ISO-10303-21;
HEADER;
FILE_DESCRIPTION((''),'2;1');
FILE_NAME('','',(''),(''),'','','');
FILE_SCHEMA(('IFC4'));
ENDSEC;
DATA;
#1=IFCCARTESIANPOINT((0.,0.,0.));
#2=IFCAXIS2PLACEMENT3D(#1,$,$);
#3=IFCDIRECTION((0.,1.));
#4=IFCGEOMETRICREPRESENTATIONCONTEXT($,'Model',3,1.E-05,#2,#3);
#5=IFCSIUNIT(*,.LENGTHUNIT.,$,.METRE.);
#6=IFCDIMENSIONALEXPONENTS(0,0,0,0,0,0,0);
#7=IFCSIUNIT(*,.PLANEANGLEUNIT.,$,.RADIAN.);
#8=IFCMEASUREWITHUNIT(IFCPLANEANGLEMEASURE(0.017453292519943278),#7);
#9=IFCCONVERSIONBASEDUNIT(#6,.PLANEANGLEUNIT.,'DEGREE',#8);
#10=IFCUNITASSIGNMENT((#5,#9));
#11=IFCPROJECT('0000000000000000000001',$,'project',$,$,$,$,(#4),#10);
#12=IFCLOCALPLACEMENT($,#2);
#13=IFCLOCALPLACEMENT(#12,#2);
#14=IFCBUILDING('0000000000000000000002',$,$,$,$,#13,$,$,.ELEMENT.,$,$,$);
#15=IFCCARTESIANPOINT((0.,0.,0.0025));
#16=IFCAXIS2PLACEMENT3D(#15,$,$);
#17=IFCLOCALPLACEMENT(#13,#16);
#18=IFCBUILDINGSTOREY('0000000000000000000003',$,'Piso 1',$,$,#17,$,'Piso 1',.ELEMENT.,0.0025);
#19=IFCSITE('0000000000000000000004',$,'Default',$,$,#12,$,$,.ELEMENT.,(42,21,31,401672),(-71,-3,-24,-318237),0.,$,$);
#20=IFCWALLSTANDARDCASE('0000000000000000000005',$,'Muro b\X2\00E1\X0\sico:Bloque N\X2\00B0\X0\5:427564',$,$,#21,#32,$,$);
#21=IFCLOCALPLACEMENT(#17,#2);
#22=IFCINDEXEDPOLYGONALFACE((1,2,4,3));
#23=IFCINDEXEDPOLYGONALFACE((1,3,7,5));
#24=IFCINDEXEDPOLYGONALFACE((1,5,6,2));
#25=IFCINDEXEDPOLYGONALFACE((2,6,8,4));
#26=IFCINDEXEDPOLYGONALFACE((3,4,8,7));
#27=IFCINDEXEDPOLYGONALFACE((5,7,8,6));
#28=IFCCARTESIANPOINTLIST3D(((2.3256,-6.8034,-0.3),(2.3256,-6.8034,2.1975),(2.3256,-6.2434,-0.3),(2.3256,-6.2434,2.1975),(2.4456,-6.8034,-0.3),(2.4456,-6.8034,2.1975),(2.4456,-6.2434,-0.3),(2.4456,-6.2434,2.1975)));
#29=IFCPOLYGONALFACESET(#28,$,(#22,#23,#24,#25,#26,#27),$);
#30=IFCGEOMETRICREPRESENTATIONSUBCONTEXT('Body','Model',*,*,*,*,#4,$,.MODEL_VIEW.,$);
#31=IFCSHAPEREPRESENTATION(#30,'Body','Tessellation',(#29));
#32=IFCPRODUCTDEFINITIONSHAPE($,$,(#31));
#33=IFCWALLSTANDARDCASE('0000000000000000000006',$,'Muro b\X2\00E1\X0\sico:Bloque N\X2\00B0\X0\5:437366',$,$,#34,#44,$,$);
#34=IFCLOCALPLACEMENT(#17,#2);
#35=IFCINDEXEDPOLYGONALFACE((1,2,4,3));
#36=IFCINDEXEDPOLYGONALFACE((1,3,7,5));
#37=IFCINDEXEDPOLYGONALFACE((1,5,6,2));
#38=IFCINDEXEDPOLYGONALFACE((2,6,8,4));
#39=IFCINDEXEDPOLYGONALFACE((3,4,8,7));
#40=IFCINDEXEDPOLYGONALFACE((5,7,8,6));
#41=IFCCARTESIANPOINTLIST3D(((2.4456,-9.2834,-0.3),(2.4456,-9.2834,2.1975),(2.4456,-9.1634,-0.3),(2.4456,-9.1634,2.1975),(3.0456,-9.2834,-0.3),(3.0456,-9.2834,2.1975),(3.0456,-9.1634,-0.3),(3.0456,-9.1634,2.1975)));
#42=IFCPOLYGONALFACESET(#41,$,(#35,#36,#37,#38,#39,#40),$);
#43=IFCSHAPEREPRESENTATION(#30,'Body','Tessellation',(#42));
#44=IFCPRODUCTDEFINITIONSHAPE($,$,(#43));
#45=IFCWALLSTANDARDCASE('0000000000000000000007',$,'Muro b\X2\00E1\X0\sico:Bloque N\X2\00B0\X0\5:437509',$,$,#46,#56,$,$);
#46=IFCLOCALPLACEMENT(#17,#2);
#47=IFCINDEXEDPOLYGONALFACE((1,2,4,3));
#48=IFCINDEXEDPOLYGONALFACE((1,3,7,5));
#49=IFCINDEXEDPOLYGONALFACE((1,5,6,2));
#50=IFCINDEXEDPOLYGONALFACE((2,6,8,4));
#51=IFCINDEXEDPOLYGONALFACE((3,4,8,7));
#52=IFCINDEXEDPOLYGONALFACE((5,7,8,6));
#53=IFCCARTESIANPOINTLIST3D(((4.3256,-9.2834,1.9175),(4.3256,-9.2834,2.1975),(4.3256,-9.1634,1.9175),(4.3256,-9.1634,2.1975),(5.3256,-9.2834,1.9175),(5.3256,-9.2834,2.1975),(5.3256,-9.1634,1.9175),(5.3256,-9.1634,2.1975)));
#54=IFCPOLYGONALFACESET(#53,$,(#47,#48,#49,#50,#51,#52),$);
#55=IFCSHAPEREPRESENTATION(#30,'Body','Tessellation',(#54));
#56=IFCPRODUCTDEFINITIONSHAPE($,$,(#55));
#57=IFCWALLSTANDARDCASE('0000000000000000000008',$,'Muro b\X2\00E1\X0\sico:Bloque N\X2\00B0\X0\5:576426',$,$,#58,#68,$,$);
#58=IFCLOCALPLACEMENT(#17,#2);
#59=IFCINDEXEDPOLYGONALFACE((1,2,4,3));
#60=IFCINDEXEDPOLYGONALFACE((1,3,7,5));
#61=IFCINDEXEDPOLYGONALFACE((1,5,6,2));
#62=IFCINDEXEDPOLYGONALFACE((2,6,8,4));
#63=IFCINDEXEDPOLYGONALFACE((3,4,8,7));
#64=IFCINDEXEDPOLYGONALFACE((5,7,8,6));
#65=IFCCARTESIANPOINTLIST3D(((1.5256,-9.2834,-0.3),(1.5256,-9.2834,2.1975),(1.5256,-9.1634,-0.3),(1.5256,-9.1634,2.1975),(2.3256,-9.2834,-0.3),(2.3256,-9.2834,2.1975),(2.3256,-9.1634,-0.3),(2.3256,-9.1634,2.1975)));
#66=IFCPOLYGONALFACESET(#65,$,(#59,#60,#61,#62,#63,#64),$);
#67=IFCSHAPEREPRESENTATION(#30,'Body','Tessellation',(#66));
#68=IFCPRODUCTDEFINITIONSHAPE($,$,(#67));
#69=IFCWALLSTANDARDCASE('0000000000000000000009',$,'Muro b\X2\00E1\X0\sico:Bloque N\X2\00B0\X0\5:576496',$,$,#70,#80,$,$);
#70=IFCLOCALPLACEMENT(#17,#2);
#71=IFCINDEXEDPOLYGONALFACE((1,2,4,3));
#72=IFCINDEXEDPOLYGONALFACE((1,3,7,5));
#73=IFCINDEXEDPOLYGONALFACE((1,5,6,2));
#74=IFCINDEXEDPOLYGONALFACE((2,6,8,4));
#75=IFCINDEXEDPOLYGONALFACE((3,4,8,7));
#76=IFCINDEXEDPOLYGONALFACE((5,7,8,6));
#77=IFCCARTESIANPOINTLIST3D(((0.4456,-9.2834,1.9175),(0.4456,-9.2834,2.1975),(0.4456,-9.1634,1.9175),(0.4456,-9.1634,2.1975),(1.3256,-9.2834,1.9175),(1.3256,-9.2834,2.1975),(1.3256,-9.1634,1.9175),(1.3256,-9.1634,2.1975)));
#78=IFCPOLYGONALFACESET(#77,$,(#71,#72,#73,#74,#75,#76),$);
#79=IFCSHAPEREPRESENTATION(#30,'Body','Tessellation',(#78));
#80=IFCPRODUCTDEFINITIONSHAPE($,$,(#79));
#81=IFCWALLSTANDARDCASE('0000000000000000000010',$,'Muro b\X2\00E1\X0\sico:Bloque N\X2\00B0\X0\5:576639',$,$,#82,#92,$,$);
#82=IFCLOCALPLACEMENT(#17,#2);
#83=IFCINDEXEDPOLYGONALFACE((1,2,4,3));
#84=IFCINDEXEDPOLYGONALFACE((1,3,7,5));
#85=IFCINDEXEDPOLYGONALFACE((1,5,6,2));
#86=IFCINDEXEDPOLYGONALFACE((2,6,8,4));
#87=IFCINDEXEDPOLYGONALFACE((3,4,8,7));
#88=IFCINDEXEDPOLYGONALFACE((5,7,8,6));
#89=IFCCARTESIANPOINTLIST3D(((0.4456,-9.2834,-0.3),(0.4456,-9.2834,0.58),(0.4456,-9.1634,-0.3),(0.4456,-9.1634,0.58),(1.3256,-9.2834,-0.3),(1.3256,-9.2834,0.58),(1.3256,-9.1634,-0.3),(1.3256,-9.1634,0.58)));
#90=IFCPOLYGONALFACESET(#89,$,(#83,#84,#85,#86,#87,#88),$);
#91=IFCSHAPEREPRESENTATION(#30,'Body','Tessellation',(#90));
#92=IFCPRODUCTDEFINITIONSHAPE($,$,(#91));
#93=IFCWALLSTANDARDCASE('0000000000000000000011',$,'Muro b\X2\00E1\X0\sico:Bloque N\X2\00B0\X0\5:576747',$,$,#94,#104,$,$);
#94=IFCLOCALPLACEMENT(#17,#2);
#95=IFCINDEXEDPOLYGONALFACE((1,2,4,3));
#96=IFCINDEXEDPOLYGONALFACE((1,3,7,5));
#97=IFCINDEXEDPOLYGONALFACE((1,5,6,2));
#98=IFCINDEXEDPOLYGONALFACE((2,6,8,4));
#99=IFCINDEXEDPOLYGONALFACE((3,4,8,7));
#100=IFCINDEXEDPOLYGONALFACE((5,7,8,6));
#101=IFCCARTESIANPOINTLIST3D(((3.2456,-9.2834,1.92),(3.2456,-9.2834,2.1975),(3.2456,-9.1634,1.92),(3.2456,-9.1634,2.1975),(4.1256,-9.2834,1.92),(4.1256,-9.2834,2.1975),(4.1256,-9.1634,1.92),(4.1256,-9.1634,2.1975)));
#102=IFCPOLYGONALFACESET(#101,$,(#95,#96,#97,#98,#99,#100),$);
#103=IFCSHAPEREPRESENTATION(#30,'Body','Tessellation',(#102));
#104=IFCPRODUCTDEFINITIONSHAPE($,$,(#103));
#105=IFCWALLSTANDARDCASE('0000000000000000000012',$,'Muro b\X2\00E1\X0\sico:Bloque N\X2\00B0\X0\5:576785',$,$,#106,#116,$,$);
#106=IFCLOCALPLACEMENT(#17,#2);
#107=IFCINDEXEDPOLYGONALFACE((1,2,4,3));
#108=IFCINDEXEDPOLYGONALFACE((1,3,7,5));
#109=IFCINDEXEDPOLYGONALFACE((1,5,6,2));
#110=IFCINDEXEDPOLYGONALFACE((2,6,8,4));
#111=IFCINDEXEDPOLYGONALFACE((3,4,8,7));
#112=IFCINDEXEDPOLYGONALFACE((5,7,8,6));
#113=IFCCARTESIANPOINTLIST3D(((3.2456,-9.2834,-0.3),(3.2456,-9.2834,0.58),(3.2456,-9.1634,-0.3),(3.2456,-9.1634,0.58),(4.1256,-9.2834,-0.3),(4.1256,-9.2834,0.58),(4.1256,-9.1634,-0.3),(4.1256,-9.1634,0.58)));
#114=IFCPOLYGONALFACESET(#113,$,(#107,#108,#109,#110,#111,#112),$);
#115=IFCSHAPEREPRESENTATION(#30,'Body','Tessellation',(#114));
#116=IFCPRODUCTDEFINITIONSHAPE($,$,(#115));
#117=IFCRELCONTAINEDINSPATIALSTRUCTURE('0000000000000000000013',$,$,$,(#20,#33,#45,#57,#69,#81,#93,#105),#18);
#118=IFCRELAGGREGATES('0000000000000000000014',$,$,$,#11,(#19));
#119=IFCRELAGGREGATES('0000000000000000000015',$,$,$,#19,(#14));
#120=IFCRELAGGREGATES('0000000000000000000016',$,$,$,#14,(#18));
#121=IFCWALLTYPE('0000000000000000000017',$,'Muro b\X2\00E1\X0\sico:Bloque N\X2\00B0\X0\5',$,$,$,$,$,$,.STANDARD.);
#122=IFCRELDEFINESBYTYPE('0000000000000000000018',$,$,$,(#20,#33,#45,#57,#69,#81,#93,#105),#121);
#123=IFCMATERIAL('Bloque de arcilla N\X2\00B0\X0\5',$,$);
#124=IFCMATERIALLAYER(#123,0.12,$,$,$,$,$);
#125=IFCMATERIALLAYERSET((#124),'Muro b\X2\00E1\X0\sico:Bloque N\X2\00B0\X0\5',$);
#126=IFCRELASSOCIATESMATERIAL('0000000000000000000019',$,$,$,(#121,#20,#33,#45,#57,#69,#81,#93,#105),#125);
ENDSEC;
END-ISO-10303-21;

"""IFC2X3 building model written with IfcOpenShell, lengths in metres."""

from ifc_helpers import new_model, entity, si_unit, converted_unit, direction, frame, frame_2d, origin, place, context, subcontext, project, spatial, rectangle, extrude, clip, halfspace, material, layer, layer_set, layer_usage, type_object, element, save


model = new_model("IFC2X3")

# Units and contexts
model_context = context("Model", 3, precision=1e-05, world=origin(), true_north=direction((0.0, 1.0)))
body_context = subcontext(model_context, "Body", "Model", "MODEL_VIEW")
ifc_project = project(units=[si_unit("LENGTHUNIT", "METRE"), converted_unit("PLANEANGLEUNIT", "DEGREE", entity("IfcPlaneAngleMeasure", 0.017453292519943278), si_unit("PLANEANGLEUNIT", "RADIAN"), dimensions=[0, 0, 0, 0, 0, 0, 0])], contexts=[model_context])

# Site, building, storey
site_placement = place(None, origin())
site = spatial("IfcSite", under=ifc_project, at=site_placement, Name="Default", CompositionType="ELEMENT", RefLatitude=(42, 21, 31, 401672), RefLongitude=(-71, -3, -24, -318237), RefElevation=0.0)
building_placement = place(site_placement, origin())
building = spatial("IfcBuilding", under=site, at=building_placement, CompositionType="ELEMENT")
storey_placement = place(building_placement, frame((0.0, 0.0, 0.0025)))
storey = spatial("IfcBuildingStorey", under=building, at=storey_placement, Name="Piso 1", LongName="Piso 1", CompositionType="ELEMENT", Elevation=0.0025)

# Walls
ifc_material_1 = material(Name="Bloque de arcilla N°5")
ifc_layer = layer(ifc_material_1, 0.12)
ifc_layer_set = layer_set([ifc_layer], Name="Muro básico:Bloque N°5")
wall_type = type_object("IfcWallType", Name="Muro básico:Bloque N°5", PredefinedType="STANDARD", material=ifc_layer_set)
ifc_layer_usage_1 = layer_usage(ifc_layer_set, "AXIS2", "NEGATIVE", 0.06)
wall_1_placement = place(storey_placement, frame((2.3856, -6.8034, -0.3), z_axis=(0.0, 0.0, 1.0), x_axis=(0.0, 1.0, 0.0)))
element("IfcWallStandardCase", 1, at=wall_1_placement, inside=storey, type_object=wall_type, material=ifc_layer_usage_1, Name="Muro básico:Bloque N°5:427564", context=body_context, shape_type="SweptSolid", body=[
    extrude(rectangle(XDim=0.56, YDim=0.12, at=frame_2d((0.28, 0.0), x_axis=(-1.0, 0.0))), origin(), (0.0, 0.0, 1.0), 2.4975),
])
ifc_layer_usage_2 = layer_usage(ifc_layer_set, "AXIS2", "NEGATIVE", 0.06)
wall_2_placement = place(storey_placement, frame((2.4456, -9.2234, -0.3)))
element("IfcWallStandardCase", 2, at=wall_2_placement, inside=storey, type_object=wall_type, material=ifc_layer_usage_2, Name="Muro básico:Bloque N°5:437366", context=body_context, shape_type="SweptSolid", body=[
    extrude(rectangle(XDim=0.6, YDim=0.12, at=frame_2d((0.3, 0.0), x_axis=(-1.0, 0.0))), origin(), (0.0, 0.0, 1.0), 2.4975),
])
ifc_layer_usage_3 = layer_usage(ifc_layer_set, "AXIS2", "NEGATIVE", 0.06)
wall_3_placement = place(storey_placement, frame((4.3256, -9.2234, 1.9175)))
element("IfcWallStandardCase", 3, at=wall_3_placement, inside=storey, type_object=wall_type, material=ifc_layer_usage_3, Name="Muro básico:Bloque N°5:437509", context=body_context, shape_type="Clipping", body=[
    clip(extrude(rectangle(XDim=1.0, YDim=0.12, at=frame_2d((0.5, 0.0), x_axis=(-1.0, 0.0))), origin(), (0.0, 0.0, 1.0), 0.28), halfspace(frame((1.0, -0.06, 0.0), z_axis=(0.0, 0.0, -1.0), x_axis=(0.0, 1.0, 0.0)), False)),
])
ifc_layer_usage_4 = layer_usage(ifc_layer_set, "AXIS2", "NEGATIVE", 0.06)
wall_4_placement = place(storey_placement, frame((2.3256, -9.2234, -0.3), z_axis=(0.0, 0.0, 1.0), x_axis=(-1.0, 0.0, 0.0)))
element("IfcWallStandardCase", 4, at=wall_4_placement, inside=storey, type_object=wall_type, material=ifc_layer_usage_4, Name="Muro básico:Bloque N°5:576426", context=body_context, shape_type="SweptSolid", body=[
    extrude(rectangle(XDim=0.8, YDim=0.12, at=frame_2d((0.4, 0.0), x_axis=(-1.0, 0.0))), origin(), (0.0, 0.0, 1.0), 2.4975),
])
ifc_layer_usage_5 = layer_usage(ifc_layer_set, "AXIS2", "NEGATIVE", 0.06)
wall_5_placement = place(storey_placement, frame((1.3256, -9.2234, 1.9175), z_axis=(0.0, 0.0, 1.0), x_axis=(-1.0, 0.0, 0.0)))
element("IfcWallStandardCase", 5, at=wall_5_placement, inside=storey, type_object=wall_type, material=ifc_layer_usage_5, Name="Muro básico:Bloque N°5:576496", context=body_context, shape_type="SweptSolid", body=[
    extrude(rectangle(XDim=0.88, YDim=0.12, at=frame_2d((0.44, 0.0), x_axis=(-1.0, 0.0))), origin(), (0.0, 0.0, 1.0), 0.28),
])
ifc_layer_usage_6 = layer_usage(ifc_layer_set, "AXIS2", "NEGATIVE", 0.06)
wall_6_placement = place(storey_placement, frame((1.3256, -9.2234, -0.3), z_axis=(0.0, 0.0, 1.0), x_axis=(-1.0, 0.0, 0.0)))
element("IfcWallStandardCase", 6, at=wall_6_placement, inside=storey, type_object=wall_type, material=ifc_layer_usage_6, Name="Muro básico:Bloque N°5:576639", context=body_context, shape_type="SweptSolid", body=[
    extrude(rectangle(XDim=0.88, YDim=0.12, at=frame_2d((0.44, 0.0), x_axis=(-1.0, 0.0))), origin(), (0.0, 0.0, 1.0), 0.88),
])
ifc_layer_usage_7 = layer_usage(ifc_layer_set, "AXIS2", "NEGATIVE", 0.06)
wall_7_placement = place(storey_placement, frame((4.1256, -9.2234, 1.92), z_axis=(0.0, 0.0, 1.0), x_axis=(-1.0, 0.0, 0.0)))
element("IfcWallStandardCase", 7, at=wall_7_placement, inside=storey, type_object=wall_type, material=ifc_layer_usage_7, Name="Muro básico:Bloque N°5:576747", context=body_context, shape_type="SweptSolid", body=[
    extrude(rectangle(XDim=0.88, YDim=0.12, at=frame_2d((0.44, 0.0), x_axis=(-1.0, 0.0))), origin(), (0.0, 0.0, 1.0), 0.2775),
])
ifc_layer_usage_8 = layer_usage(ifc_layer_set, "AXIS2", "NEGATIVE", 0.06)
wall_8_placement = place(storey_placement, frame((4.1256, -9.2234, -0.3), z_axis=(0.0, 0.0, 1.0), x_axis=(-1.0, 0.0, 0.0)))
element("IfcWallStandardCase", 8, at=wall_8_placement, inside=storey, type_object=wall_type, material=ifc_layer_usage_8, Name="Muro básico:Bloque N°5:576785", context=body_context, shape_type="SweptSolid", body=[
    extrude(rectangle(XDim=0.88, YDim=0.12, at=frame_2d((0.44, 0.0), x_axis=(-1.0, 0.0))), origin(), (0.0, 0.0, 1.0), 0.88),
])

save(model, "model.ifc")
